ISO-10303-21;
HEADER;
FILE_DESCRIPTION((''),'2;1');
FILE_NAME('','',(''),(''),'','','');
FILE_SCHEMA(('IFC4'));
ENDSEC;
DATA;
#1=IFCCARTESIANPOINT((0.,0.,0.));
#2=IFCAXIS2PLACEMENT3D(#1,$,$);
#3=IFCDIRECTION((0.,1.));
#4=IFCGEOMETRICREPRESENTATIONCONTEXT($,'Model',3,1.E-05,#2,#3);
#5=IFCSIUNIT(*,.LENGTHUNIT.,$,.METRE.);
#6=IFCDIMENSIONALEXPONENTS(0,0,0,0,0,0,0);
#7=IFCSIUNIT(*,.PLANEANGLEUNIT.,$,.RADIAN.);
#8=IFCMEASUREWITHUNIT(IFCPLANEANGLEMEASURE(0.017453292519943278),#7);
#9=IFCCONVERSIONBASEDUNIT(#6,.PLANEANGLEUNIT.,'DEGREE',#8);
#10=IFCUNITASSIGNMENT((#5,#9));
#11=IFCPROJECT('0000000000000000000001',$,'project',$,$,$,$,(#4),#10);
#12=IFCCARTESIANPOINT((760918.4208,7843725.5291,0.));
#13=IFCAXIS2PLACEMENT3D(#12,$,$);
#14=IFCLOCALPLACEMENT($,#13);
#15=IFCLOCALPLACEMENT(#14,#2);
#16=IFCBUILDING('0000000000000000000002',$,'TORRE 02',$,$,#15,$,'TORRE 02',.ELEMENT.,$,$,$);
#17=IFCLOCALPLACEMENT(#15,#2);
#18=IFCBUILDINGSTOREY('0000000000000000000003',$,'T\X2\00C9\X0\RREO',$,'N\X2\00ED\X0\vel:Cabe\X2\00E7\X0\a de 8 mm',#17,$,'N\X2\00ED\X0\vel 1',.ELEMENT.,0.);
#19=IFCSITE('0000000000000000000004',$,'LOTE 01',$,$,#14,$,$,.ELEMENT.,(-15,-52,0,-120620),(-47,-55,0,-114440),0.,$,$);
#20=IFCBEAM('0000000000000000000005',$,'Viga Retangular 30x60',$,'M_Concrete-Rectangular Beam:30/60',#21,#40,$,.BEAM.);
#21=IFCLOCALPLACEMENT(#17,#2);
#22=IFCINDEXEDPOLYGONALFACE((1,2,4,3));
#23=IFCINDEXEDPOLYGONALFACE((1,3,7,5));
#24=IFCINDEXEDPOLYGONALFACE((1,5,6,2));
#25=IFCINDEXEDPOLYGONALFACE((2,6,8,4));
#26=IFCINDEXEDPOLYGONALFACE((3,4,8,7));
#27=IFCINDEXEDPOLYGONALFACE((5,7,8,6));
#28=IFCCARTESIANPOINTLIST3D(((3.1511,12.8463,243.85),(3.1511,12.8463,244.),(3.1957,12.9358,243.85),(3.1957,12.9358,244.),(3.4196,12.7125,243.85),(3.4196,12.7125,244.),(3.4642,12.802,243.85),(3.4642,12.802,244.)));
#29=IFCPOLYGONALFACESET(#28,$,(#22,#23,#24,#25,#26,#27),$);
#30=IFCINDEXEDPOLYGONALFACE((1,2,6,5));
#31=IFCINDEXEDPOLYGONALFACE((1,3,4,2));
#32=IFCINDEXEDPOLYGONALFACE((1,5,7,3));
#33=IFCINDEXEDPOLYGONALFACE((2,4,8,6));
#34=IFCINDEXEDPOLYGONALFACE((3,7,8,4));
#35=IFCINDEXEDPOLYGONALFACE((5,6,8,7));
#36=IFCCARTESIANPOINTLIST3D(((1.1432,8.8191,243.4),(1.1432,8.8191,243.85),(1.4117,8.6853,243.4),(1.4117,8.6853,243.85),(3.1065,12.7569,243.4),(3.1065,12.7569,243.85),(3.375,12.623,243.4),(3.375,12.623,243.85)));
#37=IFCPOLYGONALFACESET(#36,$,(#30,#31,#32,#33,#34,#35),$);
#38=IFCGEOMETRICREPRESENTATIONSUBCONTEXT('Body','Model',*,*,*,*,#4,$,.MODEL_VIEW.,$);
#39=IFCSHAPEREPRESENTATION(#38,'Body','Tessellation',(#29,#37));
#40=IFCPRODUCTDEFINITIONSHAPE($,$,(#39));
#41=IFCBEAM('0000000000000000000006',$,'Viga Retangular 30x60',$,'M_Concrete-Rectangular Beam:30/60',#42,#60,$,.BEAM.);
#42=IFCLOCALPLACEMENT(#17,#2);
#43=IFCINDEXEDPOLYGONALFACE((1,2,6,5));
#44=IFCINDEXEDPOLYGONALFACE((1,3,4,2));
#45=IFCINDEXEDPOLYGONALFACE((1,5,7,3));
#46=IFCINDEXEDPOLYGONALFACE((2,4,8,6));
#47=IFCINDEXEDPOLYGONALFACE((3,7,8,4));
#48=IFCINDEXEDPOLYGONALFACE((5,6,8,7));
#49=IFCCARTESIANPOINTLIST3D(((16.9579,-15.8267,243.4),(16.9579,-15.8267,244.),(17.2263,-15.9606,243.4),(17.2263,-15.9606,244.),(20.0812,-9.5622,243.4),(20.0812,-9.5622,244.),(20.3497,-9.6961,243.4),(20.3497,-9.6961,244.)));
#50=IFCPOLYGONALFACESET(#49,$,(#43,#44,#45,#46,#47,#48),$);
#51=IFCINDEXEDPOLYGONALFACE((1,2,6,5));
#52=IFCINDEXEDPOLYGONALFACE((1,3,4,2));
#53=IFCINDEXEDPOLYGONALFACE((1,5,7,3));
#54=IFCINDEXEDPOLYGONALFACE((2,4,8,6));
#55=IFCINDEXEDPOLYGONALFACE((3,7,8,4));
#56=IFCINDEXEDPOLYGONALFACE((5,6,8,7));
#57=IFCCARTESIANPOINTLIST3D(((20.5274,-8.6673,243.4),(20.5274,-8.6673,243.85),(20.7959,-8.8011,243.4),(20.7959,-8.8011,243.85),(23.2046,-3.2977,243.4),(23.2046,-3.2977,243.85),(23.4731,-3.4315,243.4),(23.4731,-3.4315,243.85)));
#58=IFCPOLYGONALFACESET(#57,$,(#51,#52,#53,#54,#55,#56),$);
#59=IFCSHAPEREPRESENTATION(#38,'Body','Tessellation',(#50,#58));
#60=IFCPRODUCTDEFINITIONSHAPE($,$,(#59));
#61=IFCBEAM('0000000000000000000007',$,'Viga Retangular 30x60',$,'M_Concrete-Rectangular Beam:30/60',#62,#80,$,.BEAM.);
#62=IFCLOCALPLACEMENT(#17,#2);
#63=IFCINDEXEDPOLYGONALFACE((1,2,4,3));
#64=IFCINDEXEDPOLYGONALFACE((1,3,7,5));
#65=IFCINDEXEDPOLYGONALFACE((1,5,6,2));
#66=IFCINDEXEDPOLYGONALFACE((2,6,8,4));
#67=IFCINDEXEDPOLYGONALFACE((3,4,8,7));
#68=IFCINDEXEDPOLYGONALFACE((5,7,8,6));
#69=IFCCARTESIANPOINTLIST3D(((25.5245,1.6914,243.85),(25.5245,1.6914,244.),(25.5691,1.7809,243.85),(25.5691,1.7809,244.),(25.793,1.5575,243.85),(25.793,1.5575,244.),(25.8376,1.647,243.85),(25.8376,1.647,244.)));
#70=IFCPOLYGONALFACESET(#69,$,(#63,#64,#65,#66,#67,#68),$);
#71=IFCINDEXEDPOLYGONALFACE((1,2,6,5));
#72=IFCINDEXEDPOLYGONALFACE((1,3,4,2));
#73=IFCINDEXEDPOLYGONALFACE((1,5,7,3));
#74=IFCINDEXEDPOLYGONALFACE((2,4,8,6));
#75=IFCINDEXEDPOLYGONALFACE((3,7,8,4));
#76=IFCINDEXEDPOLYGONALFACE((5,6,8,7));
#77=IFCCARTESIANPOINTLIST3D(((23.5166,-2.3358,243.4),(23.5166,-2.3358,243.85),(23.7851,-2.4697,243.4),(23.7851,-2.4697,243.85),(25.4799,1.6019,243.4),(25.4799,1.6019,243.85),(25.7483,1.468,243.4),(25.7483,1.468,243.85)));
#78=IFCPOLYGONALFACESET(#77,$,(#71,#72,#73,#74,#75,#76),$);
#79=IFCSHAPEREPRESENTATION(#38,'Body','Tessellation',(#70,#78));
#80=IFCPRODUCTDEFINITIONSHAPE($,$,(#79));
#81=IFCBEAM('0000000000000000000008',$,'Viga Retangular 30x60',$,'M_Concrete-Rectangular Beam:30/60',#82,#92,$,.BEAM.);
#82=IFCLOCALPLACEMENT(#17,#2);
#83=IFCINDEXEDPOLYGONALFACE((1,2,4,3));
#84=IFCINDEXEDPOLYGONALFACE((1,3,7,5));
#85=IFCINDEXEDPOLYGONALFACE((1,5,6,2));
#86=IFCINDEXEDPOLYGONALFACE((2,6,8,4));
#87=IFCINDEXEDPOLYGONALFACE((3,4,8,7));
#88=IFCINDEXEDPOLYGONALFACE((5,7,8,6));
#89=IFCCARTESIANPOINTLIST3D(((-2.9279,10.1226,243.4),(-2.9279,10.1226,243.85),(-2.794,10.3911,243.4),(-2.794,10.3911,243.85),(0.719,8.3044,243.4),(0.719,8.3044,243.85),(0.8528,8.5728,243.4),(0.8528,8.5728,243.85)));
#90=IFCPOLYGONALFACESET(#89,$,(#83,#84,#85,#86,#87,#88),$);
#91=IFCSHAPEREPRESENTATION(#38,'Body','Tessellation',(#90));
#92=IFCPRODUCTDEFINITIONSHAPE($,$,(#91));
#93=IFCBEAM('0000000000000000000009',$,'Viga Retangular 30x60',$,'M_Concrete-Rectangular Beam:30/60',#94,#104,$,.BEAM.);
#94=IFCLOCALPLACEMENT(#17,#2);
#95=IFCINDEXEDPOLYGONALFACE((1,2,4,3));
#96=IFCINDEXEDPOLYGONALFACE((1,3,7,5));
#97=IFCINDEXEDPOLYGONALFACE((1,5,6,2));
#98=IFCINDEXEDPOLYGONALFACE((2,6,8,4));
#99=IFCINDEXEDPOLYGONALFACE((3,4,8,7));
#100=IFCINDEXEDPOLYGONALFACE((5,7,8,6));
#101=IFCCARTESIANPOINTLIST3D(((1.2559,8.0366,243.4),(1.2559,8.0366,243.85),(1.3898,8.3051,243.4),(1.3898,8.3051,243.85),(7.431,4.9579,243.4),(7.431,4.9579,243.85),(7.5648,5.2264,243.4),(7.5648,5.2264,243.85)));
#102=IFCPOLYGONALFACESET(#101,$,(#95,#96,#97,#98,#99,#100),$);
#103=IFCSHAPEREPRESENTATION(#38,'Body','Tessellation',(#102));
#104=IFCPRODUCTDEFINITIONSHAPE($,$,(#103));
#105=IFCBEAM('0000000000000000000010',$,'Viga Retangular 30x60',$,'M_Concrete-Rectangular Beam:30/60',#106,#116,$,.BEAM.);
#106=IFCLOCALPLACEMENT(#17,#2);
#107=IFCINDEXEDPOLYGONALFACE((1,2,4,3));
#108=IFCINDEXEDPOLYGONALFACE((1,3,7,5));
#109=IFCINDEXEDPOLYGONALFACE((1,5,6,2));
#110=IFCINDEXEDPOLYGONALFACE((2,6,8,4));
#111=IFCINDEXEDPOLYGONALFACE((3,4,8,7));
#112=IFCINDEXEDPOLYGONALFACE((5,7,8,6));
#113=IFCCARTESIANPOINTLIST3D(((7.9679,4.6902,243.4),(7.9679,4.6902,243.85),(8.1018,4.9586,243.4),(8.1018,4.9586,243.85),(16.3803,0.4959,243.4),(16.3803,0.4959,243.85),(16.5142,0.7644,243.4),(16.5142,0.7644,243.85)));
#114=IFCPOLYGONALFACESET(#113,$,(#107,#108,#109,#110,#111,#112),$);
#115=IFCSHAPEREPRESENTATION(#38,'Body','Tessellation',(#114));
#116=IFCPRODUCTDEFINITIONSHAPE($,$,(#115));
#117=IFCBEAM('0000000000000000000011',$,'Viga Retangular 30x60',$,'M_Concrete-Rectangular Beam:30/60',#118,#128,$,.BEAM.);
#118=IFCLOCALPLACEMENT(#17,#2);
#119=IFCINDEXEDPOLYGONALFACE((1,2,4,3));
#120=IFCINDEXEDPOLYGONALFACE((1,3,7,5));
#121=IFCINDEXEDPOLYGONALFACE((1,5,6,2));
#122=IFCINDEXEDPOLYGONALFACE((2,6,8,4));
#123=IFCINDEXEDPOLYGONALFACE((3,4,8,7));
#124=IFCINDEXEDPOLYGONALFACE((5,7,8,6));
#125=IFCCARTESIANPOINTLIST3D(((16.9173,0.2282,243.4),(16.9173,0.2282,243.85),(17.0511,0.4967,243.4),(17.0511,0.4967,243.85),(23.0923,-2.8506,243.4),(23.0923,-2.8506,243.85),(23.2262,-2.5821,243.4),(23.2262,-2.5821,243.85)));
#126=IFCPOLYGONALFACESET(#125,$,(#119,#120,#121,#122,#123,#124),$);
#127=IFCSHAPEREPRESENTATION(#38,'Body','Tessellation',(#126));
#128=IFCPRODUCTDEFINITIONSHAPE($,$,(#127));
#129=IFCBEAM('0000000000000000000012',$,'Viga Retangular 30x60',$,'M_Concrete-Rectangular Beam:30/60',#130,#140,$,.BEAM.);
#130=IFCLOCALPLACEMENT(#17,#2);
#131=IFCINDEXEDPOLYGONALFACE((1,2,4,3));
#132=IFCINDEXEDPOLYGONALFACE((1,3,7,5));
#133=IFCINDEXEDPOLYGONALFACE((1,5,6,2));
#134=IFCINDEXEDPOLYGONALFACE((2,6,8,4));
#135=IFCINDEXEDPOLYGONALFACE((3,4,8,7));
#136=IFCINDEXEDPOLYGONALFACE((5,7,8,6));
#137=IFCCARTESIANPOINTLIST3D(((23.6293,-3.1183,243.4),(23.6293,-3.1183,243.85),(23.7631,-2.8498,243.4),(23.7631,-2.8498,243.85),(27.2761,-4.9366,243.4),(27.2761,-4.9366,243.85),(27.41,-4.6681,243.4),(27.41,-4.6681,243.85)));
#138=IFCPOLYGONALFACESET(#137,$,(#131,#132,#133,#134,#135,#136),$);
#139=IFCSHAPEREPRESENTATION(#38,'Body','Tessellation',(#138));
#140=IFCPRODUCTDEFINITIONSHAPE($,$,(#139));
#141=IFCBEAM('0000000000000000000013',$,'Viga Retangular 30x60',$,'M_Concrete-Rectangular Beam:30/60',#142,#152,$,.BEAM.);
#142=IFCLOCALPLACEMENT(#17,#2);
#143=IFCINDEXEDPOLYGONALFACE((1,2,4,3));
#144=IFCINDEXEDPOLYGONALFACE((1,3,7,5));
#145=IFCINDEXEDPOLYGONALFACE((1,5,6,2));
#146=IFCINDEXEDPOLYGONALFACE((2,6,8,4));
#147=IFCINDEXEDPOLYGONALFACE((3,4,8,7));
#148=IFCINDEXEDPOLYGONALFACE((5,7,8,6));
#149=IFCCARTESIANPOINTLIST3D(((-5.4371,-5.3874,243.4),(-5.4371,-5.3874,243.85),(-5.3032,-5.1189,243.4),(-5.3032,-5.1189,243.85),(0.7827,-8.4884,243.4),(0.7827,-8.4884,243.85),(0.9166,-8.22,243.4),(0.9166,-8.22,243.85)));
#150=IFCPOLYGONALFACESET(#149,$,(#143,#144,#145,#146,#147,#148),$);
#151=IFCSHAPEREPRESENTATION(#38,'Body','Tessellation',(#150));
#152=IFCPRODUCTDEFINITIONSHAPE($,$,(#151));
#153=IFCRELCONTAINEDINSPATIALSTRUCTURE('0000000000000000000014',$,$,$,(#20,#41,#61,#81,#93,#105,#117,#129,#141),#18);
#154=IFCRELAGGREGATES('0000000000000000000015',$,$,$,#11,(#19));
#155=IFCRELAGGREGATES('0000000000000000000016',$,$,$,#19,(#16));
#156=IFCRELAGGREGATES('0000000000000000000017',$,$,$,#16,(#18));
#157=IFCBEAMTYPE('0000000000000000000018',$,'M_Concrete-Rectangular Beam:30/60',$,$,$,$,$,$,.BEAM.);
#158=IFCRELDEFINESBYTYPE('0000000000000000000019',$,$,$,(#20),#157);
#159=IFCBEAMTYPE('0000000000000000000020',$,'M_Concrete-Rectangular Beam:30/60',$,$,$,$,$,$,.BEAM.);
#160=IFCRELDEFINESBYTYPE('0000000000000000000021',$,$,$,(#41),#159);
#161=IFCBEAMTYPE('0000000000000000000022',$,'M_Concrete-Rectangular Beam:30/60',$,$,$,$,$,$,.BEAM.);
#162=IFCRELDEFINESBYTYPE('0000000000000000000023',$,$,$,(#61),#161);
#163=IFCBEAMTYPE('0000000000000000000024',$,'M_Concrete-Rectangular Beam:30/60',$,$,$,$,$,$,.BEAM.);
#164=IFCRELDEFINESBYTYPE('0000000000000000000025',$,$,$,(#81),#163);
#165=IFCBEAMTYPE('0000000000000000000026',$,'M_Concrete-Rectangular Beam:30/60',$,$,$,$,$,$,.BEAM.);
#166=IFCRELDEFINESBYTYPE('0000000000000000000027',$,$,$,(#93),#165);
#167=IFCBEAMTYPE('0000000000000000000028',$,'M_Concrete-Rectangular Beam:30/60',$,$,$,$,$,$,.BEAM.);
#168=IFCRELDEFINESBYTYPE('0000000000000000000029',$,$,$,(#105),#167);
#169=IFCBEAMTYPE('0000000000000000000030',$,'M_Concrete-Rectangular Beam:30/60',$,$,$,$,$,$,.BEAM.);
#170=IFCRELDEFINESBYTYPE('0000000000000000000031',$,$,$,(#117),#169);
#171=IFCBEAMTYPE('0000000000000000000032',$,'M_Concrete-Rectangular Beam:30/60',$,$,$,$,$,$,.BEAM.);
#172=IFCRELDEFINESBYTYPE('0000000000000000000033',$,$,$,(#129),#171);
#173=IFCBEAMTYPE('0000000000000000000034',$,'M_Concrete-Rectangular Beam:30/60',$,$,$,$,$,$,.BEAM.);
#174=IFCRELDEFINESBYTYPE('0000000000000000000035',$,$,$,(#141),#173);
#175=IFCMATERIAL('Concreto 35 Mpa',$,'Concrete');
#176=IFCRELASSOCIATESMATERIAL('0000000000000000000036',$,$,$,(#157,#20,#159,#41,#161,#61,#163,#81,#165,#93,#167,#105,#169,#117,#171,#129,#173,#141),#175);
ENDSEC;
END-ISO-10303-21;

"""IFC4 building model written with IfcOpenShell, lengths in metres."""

from ifc_helpers import new_model, entity, si_unit, converted_unit, direction, frame, origin, place, context, subcontext, project, spatial, indexed_curve, outline, extrude, source, transform, mapped, material, type_object, type_shapes, element, save


model = new_model("IFC4")

# Units and contexts
model_context = context("Model", 3, precision=1e-05, world=origin(), true_north=direction((0.0, 1.0)))
body_context = subcontext(model_context, "Body", "Model", "MODEL_VIEW")
ifc_project = project(units=[si_unit("LENGTHUNIT", "METRE"), converted_unit("PLANEANGLEUNIT", "DEGREE", entity("IfcPlaneAngleMeasure", 0.017453292519943278), si_unit("PLANEANGLEUNIT", "RADIAN"), dimensions=[0, 0, 0, 0, 0, 0, 0])], contexts=[model_context])

# Site, building, storey
site_placement = place(None, frame((760918.4208, 7843725.5291, 0.0)))
site = spatial("IfcSite", under=ifc_project, at=site_placement, Name="LOTE 01", CompositionType="ELEMENT", RefLatitude=(-15, -52, 0, -120620), RefLongitude=(-47, -55, 0, -114440), RefElevation=0.0)
building_placement = place(site_placement, origin())
building = spatial("IfcBuilding", under=site, at=building_placement, Name="TORRE 02", LongName="TORRE 02", CompositionType="ELEMENT")
storey_placement = place(building_placement, origin())
storey = spatial("IfcBuildingStorey", under=building, at=storey_placement, Name="TÉRREO", ObjectType="Nível:Cabeça de 8 mm", LongName="Nível 1", CompositionType="ELEMENT", Elevation=0.0)

# Shared definitions
placement = place(building_placement, frame((0.0, 0.0, 244.0)))

# Beams
ifc_material_1 = material(Name="Concreto 35 Mpa", Category="Concrete")
beam_type_1 = type_object("IfcBeamType", Name="M_Concrete-Rectangular Beam:30/60", PredefinedType="BEAM", material=ifc_material_1)
shared_shape_1 = source(origin(), body_context, "Body", "SweptSolid", [
    extrude(outline(indexed_curve([(-0.075, -0.15), (0.075, -0.15), (0.075, 0.15), (-0.075, 0.15), (-0.075, -0.15)], self_intersect=False)), frame((3.2854, 12.7794, 243.925), z_axis=(0.446198, 0.894934, 0.0), x_axis=(0.0, 0.0, 1.0)), (0.0, 0.0, 1.0), 0.1),
    extrude(outline(indexed_curve([(-0.225, -0.15), (0.225, -0.15), (0.225, 0.15), (-0.225, 0.15), (-0.225, -0.15)], self_intersect=False)), frame((1.2775, 8.7522, 243.625), z_axis=(0.446198, 0.894934, 0.0), x_axis=(0.0, 0.0, 1.0)), (0.0, 0.0, 1.0), 4.4),
])
type_shapes(beam_type_1, [shared_shape_1])
beam_1_placement = place(placement, frame((0.0, 0.0, -244.0)))
element("IfcBeam", 1, at=beam_1_placement, inside=storey, type_object=beam_type_1, material=ifc_material_1, Name="Viga Retangular 30x60", ObjectType="M_Concrete-Rectangular Beam:30/60", PredefinedType="BEAM", context=body_context, shape_type="MappedRepresentation", body=[
    mapped(shared_shape_1, transform((0.0, 0.0, 0.0), scale=1.0)),
])
beam_type_2 = type_object("IfcBeamType", Name="M_Concrete-Rectangular Beam:30/60", PredefinedType="BEAM", material=ifc_material_1)
shared_shape_2 = source(origin(), body_context, "Body", "SweptSolid", [
    extrude(outline(indexed_curve([(-0.3, -0.15), (0.3, -0.15), (0.3, 0.15), (-0.3, 0.15), (-0.3, -0.15)], self_intersect=False)), frame((17.0921, -15.8937, 243.7), z_axis=(0.446198, 0.894934, 0.0), x_axis=(0.0, 0.0, 1.0)), (0.0, 0.0, 1.0), 7.0),
    extrude(outline(indexed_curve([(-0.225, -0.15), (0.225, -0.15), (0.225, 0.15), (-0.225, 0.15), (-0.225, -0.15)], self_intersect=False)), frame((20.6617, -8.7342, 243.625), z_axis=(0.446198, 0.894934, 0.0), x_axis=(0.0, 0.0, 1.0)), (0.0, 0.0, 1.0), 6.0),
])
type_shapes(beam_type_2, [shared_shape_2])
beam_2_placement = place(placement, frame((0.0, 0.0, -244.0)))
element("IfcBeam", 2, at=beam_2_placement, inside=storey, type_object=beam_type_2, material=ifc_material_1, Name="Viga Retangular 30x60", ObjectType="M_Concrete-Rectangular Beam:30/60", PredefinedType="BEAM", context=body_context, shape_type="MappedRepresentation", body=[
    mapped(shared_shape_2, transform((0.0, 0.0, 0.0), scale=1.0)),
])
beam_type_3 = type_object("IfcBeamType", Name="M_Concrete-Rectangular Beam:30/60", PredefinedType="BEAM", material=ifc_material_1)
shared_shape_3 = source(origin(), body_context, "Body", "SweptSolid", [
    extrude(outline(indexed_curve([(-0.075, -0.15), (0.075, -0.15), (0.075, 0.15), (-0.075, 0.15), (-0.075, -0.15)], self_intersect=False)), frame((25.6587, 1.6245, 243.925), z_axis=(0.446198, 0.894934, 0.0), x_axis=(0.0, 0.0, 1.0)), (0.0, 0.0, 1.0), 0.1),
    extrude(outline(indexed_curve([(-0.225, -0.15), (0.225, -0.15), (0.225, 0.15), (-0.225, 0.15), (-0.225, -0.15)], self_intersect=False)), frame((23.6508, -2.4027, 243.625), z_axis=(0.446198, 0.894934, 0.0), x_axis=(0.0, 0.0, 1.0)), (0.0, 0.0, 1.0), 4.4),
])
type_shapes(beam_type_3, [shared_shape_3])
beam_3_placement = place(placement, frame((0.0, 0.0, -244.0)))
element("IfcBeam", 3, at=beam_3_placement, inside=storey, type_object=beam_type_3, material=ifc_material_1, Name="Viga Retangular 30x60", ObjectType="M_Concrete-Rectangular Beam:30/60", PredefinedType="BEAM", context=body_context, shape_type="MappedRepresentation", body=[
    mapped(shared_shape_3, transform((0.0, 0.0, 0.0), scale=1.0)),
])
beam_type_4 = type_object("IfcBeamType", Name="M_Concrete-Rectangular Beam:30/60", PredefinedType="BEAM", material=ifc_material_1)
shared_shape_4 = source(origin(), body_context, "Body", "SweptSolid", [
    extrude(outline(indexed_curve([(-0.225, -0.15), (0.225, -0.15), (0.225, 0.15), (-0.225, 0.15), (-0.225, -0.15)], self_intersect=False)), frame((-2.861, 10.2569, 243.625), z_axis=(0.894934, -0.446198, 0.0), x_axis=(0.0, 0.0, -1.0)), (0.0, 0.0, 1.0), 4.075),
])
type_shapes(beam_type_4, [shared_shape_4])
beam_4_placement = place(placement, frame((0.0, 0.0, -244.0)))
element("IfcBeam", 4, at=beam_4_placement, inside=storey, type_object=beam_type_4, material=ifc_material_1, Name="Viga Retangular 30x60", ObjectType="M_Concrete-Rectangular Beam:30/60", PredefinedType="BEAM", context=body_context, shape_type="MappedRepresentation", body=[
    mapped(shared_shape_4, transform((0.0, 0.0, 0.0), scale=1.0)),
])
beam_type_5 = type_object("IfcBeamType", Name="M_Concrete-Rectangular Beam:30/60", PredefinedType="BEAM", material=ifc_material_1)
shared_shape_5 = source(origin(), body_context, "Body", "SweptSolid", [
    extrude(outline(indexed_curve([(-0.225, -0.15), (0.225, -0.15), (0.225, 0.15), (-0.225, 0.15), (-0.225, -0.15)], self_intersect=False)), frame((1.3228, 8.1709, 243.625), z_axis=(0.894934, -0.446198, 0.0), x_axis=(0.0, 0.0, -1.0)), (0.0, 0.0, 1.0), 6.9),
])
type_shapes(beam_type_5, [shared_shape_5])
beam_5_placement = place(placement, frame((0.0, 0.0, -244.0)))
element("IfcBeam", 5, at=beam_5_placement, inside=storey, type_object=beam_type_5, material=ifc_material_1, Name="Viga Retangular 30x60", ObjectType="M_Concrete-Rectangular Beam:30/60", PredefinedType="BEAM", context=body_context, shape_type="MappedRepresentation", body=[
    mapped(shared_shape_5, transform((0.0, 0.0, 0.0), scale=1.0)),
])
beam_type_6 = type_object("IfcBeamType", Name="M_Concrete-Rectangular Beam:30/60", PredefinedType="BEAM", material=ifc_material_1)
shared_shape_6 = source(origin(), body_context, "Body", "SweptSolid", [
    extrude(outline(indexed_curve([(-0.225, -0.15), (0.225, -0.15), (0.225, 0.15), (-0.225, 0.15), (-0.225, -0.15)], self_intersect=False)), frame((8.0349, 4.8244, 243.625), z_axis=(0.894934, -0.446198, 0.0), x_axis=(0.0, 0.0, -1.0)), (0.0, 0.0, 1.0), 9.4),
])
type_shapes(beam_type_6, [shared_shape_6])
beam_6_placement = place(placement, frame((0.0, 0.0, -244.0)))
element("IfcBeam", 6, at=beam_6_placement, inside=storey, type_object=beam_type_6, material=ifc_material_1, Name="Viga Retangular 30x60", ObjectType="M_Concrete-Rectangular Beam:30/60", PredefinedType="BEAM", context=body_context, shape_type="MappedRepresentation", body=[
    mapped(shared_shape_6, transform((0.0, 0.0, 0.0), scale=1.0)),
])
beam_type_7 = type_object("IfcBeamType", Name="M_Concrete-Rectangular Beam:30/60", PredefinedType="BEAM", material=ifc_material_1)
shared_shape_7 = source(origin(), body_context, "Body", "SweptSolid", [
    extrude(outline(indexed_curve([(-0.225, -0.15), (0.225, -0.15), (0.225, 0.15), (-0.225, 0.15), (-0.225, -0.15)], self_intersect=False)), frame((16.9842, 0.3624, 243.625), z_axis=(0.894934, -0.446198, 0.0), x_axis=(0.0, 0.0, -1.0)), (0.0, 0.0, 1.0), 6.9),
])
type_shapes(beam_type_7, [shared_shape_7])
beam_7_placement = place(placement, frame((0.0, 0.0, -244.0)))
element("IfcBeam", 7, at=beam_7_placement, inside=storey, type_object=beam_type_7, material=ifc_material_1, Name="Viga Retangular 30x60", ObjectType="M_Concrete-Rectangular Beam:30/60", PredefinedType="BEAM", context=body_context, shape_type="MappedRepresentation", body=[
    mapped(shared_shape_7, transform((0.0, 0.0, 0.0), scale=1.0)),
])
beam_type_8 = type_object("IfcBeamType", Name="M_Concrete-Rectangular Beam:30/60", PredefinedType="BEAM", material=ifc_material_1)
shared_shape_8 = source(origin(), body_context, "Body", "SweptSolid", [
    extrude(outline(indexed_curve([(-0.225, -0.15), (0.225, -0.15), (0.225, 0.15), (-0.225, 0.15), (-0.225, -0.15)], self_intersect=False)), frame((23.6962, -2.9841, 243.625), z_axis=(0.894934, -0.446198, 0.0), x_axis=(0.0, 0.0, -1.0)), (0.0, 0.0, 1.0), 4.075),
])
type_shapes(beam_type_8, [shared_shape_8])
beam_8_placement = place(placement, frame((0.0, 0.0, -244.0)))
element("IfcBeam", 8, at=beam_8_placement, inside=storey, type_object=beam_type_8, material=ifc_material_1, Name="Viga Retangular 30x60", ObjectType="M_Concrete-Rectangular Beam:30/60", PredefinedType="BEAM", context=body_context, shape_type="MappedRepresentation", body=[
    mapped(shared_shape_8, transform((0.0, 0.0, 0.0), scale=1.0)),
])
beam_type_9 = type_object("IfcBeamType", Name="M_Concrete-Rectangular Beam:30/60", PredefinedType="BEAM", material=ifc_material_1)
shared_shape_9 = source(origin(), body_context, "Body", "SweptSolid", [
    extrude(outline(indexed_curve([(-0.225, -0.15), (0.225, -0.15), (0.225, 0.15), (-0.225, 0.15), (-0.225, -0.15)], self_intersect=False)), frame((-5.3701, -5.2531, 243.625), z_axis=(0.894934, -0.446198, 0.0), x_axis=(0.0, 0.0, -1.0)), (0.0, 0.0, 1.0), 6.95),
])
type_shapes(beam_type_9, [shared_shape_9])
beam_9_placement = place(placement, frame((0.0, 0.0, -244.0)))
element("IfcBeam", 9, at=beam_9_placement, inside=storey, type_object=beam_type_9, material=ifc_material_1, Name="Viga Retangular 30x60", ObjectType="M_Concrete-Rectangular Beam:30/60", PredefinedType="BEAM", context=body_context, shape_type="MappedRepresentation", body=[
    mapped(shared_shape_9, transform((0.0, 0.0, 0.0), scale=1.0)),
])

save(model, "model.ifc")
